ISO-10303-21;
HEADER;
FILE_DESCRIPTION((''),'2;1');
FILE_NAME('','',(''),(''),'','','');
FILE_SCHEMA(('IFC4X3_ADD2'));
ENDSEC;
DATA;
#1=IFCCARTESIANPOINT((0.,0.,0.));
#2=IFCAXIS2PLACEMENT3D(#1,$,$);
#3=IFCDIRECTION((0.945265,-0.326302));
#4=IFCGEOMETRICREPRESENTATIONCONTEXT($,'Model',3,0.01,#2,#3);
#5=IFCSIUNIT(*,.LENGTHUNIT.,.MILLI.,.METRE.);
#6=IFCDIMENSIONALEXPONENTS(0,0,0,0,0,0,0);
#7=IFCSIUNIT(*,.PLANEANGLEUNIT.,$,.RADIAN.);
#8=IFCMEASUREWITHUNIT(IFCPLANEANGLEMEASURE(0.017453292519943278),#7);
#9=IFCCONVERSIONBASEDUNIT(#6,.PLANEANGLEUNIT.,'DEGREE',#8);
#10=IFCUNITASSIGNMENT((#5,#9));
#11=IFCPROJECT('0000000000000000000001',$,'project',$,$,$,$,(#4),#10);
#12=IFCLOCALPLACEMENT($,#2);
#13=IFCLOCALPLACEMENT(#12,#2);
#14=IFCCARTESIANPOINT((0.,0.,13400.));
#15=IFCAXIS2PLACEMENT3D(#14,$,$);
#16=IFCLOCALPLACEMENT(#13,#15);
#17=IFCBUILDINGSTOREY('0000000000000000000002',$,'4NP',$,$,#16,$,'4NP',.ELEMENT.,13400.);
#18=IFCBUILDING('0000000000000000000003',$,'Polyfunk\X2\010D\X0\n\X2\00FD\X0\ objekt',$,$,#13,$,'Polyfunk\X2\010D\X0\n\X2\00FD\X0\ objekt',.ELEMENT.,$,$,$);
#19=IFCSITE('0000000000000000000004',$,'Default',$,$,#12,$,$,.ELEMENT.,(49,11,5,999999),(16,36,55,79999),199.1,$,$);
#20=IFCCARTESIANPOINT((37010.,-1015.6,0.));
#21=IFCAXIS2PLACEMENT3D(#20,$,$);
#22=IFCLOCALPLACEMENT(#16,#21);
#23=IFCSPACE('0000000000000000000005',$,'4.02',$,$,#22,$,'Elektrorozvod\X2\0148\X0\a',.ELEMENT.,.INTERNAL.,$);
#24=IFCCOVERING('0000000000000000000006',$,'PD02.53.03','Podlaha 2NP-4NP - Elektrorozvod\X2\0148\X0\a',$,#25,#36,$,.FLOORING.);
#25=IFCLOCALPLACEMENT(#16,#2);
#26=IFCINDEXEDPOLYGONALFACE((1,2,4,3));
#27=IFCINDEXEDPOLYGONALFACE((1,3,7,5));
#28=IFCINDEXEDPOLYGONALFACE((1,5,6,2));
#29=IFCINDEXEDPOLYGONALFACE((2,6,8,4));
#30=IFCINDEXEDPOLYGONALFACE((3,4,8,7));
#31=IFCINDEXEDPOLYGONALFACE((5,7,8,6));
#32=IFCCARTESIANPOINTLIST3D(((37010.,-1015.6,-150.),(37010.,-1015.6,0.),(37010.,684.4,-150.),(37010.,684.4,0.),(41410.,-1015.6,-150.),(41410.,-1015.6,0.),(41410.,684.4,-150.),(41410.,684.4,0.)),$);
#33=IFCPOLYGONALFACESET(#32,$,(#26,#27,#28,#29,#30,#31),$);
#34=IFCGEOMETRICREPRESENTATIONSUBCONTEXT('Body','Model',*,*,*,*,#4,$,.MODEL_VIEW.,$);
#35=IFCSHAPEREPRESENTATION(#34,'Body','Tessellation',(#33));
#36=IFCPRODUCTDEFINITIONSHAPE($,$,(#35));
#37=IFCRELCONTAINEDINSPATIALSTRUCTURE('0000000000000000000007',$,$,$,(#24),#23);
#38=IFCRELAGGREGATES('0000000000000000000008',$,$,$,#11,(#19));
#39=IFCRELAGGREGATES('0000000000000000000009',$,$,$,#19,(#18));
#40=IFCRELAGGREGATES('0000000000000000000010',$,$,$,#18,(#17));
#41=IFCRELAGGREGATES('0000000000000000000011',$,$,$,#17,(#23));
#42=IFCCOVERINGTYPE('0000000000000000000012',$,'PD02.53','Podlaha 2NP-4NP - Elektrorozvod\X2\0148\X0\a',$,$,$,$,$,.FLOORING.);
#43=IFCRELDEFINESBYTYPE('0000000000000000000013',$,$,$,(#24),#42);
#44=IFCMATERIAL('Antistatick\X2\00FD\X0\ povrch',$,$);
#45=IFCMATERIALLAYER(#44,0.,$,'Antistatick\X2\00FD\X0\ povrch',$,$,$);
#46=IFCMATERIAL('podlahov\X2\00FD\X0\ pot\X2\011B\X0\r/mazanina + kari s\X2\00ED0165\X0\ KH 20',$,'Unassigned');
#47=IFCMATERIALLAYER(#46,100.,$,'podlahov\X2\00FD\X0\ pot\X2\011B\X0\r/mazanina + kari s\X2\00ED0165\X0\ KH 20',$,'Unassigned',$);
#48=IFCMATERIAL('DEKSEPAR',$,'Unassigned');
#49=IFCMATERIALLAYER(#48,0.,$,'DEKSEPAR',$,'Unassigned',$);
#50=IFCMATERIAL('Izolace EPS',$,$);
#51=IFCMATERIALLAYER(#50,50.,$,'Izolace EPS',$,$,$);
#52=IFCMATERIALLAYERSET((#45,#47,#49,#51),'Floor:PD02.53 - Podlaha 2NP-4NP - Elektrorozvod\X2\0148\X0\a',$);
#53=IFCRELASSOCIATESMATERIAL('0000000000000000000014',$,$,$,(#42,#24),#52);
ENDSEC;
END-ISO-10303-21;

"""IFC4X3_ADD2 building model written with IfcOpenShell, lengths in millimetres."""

from ifc_helpers import new_model, entity, si_unit, converted_unit, direction, frame, frame_2d, origin, place, context, subcontext, project, spatial, rectangle, extrude, material, layer, layer_set, layer_usage, type_object, element, save


model = new_model("IFC4X3_ADD2")

# Units and contexts
model_context = context("Model", 3, precision=0.01, world=origin(), true_north=direction((0.945265, -0.326302)))
body_context = subcontext(model_context, "Body", "Model", "MODEL_VIEW")
ifc_project = project(units=[si_unit("LENGTHUNIT", "METRE", prefix="MILLI"), converted_unit("PLANEANGLEUNIT", "DEGREE", entity("IfcPlaneAngleMeasure", 0.017453292519943278), si_unit("PLANEANGLEUNIT", "RADIAN"), dimensions=[0, 0, 0, 0, 0, 0, 0])], contexts=[model_context])

# Site, building, storey
site_placement = place(None, origin())
site = spatial("IfcSite", under=ifc_project, at=site_placement, Name="Default", CompositionType="ELEMENT", RefLatitude=(49, 11, 5, 999999), RefLongitude=(16, 36, 55, 79999), RefElevation=199.1)
building_placement = place(site_placement, origin())
building = spatial("IfcBuilding", under=site, at=building_placement, Name="Polyfunkčný objekt", LongName="Polyfunkčný objekt", CompositionType="ELEMENT")
storey_placement = place(building_placement, frame((0.0, 0.0, 13400.0)))
storey = spatial("IfcBuildingStorey", under=building, at=storey_placement, Name="4NP", LongName="4NP", CompositionType="ELEMENT", Elevation=13400.0)

# Shared definitions
ifc_material_1 = material(Name="Izolace EPS")

# Shared definitions
ifc_material_2 = material(Name="podlahový potěr/mazanina + kari síť KH 20", Category="Unassigned")
ifc_material_3 = material(Name="DEKSEPAR", Category="Unassigned")

# Shared definitions
space_1_placement = place(storey_placement, frame((37010.0, -1015.6, 0.0)))
space_1 = spatial("IfcSpace", under=storey, at=space_1_placement, Name="4.02", LongName="Elektrorozvodňa", CompositionType="ELEMENT", PredefinedType="INTERNAL")

# Covering
ifc_material_4 = material(Name="Antistatický povrch")
ifc_layer_1 = layer(ifc_material_4, 0.0, Name="Antistatický povrch")
ifc_layer_2 = layer(ifc_material_2, 100.0, Name="podlahový potěr/mazanina + kari síť KH 20", Category="Unassigned")
ifc_layer_3 = layer(ifc_material_3, 0.0, Name="DEKSEPAR", Category="Unassigned")
ifc_layer_4 = layer(ifc_material_1, 50.0, Name="Izolace EPS")
ifc_layer_set_1 = layer_set([ifc_layer_1, ifc_layer_2, ifc_layer_3, ifc_layer_4], Name="Floor:PD02.53 - Podlaha 2NP-4NP - Elektrorozvodňa")
ifc_layer_usage_1 = layer_usage(ifc_layer_set_1, "AXIS3", "POSITIVE", 0.0)
covering_type_1 = type_object("IfcCoveringType", Name="PD02.53", Description="Podlaha 2NP-4NP - Elektrorozvodňa", PredefinedType="FLOORING", material=ifc_layer_set_1)
covering_1_placement = place(storey_placement, origin())
element("IfcCovering", 1, at=covering_1_placement, inside=space_1, type_object=covering_type_1, material=ifc_layer_usage_1, Name="PD02.53.03", Description="Podlaha 2NP-4NP - Elektrorozvodňa", PredefinedType="FLOORING", context=body_context, shape_type="SweptSolid", body=[
    extrude(rectangle(XDim=1700.0, YDim=4400.0, at=frame_2d((0.0, 0.0), x_axis=(1.0, 0.0))), frame((39210.0, -165.6, 0.0), z_axis=(0.0, 0.0, -1.0), x_axis=(0.0, 1.0, 0.0)), (0.0, 0.0, 1.0), 150.0),
])

save(model, "model.ifc")
